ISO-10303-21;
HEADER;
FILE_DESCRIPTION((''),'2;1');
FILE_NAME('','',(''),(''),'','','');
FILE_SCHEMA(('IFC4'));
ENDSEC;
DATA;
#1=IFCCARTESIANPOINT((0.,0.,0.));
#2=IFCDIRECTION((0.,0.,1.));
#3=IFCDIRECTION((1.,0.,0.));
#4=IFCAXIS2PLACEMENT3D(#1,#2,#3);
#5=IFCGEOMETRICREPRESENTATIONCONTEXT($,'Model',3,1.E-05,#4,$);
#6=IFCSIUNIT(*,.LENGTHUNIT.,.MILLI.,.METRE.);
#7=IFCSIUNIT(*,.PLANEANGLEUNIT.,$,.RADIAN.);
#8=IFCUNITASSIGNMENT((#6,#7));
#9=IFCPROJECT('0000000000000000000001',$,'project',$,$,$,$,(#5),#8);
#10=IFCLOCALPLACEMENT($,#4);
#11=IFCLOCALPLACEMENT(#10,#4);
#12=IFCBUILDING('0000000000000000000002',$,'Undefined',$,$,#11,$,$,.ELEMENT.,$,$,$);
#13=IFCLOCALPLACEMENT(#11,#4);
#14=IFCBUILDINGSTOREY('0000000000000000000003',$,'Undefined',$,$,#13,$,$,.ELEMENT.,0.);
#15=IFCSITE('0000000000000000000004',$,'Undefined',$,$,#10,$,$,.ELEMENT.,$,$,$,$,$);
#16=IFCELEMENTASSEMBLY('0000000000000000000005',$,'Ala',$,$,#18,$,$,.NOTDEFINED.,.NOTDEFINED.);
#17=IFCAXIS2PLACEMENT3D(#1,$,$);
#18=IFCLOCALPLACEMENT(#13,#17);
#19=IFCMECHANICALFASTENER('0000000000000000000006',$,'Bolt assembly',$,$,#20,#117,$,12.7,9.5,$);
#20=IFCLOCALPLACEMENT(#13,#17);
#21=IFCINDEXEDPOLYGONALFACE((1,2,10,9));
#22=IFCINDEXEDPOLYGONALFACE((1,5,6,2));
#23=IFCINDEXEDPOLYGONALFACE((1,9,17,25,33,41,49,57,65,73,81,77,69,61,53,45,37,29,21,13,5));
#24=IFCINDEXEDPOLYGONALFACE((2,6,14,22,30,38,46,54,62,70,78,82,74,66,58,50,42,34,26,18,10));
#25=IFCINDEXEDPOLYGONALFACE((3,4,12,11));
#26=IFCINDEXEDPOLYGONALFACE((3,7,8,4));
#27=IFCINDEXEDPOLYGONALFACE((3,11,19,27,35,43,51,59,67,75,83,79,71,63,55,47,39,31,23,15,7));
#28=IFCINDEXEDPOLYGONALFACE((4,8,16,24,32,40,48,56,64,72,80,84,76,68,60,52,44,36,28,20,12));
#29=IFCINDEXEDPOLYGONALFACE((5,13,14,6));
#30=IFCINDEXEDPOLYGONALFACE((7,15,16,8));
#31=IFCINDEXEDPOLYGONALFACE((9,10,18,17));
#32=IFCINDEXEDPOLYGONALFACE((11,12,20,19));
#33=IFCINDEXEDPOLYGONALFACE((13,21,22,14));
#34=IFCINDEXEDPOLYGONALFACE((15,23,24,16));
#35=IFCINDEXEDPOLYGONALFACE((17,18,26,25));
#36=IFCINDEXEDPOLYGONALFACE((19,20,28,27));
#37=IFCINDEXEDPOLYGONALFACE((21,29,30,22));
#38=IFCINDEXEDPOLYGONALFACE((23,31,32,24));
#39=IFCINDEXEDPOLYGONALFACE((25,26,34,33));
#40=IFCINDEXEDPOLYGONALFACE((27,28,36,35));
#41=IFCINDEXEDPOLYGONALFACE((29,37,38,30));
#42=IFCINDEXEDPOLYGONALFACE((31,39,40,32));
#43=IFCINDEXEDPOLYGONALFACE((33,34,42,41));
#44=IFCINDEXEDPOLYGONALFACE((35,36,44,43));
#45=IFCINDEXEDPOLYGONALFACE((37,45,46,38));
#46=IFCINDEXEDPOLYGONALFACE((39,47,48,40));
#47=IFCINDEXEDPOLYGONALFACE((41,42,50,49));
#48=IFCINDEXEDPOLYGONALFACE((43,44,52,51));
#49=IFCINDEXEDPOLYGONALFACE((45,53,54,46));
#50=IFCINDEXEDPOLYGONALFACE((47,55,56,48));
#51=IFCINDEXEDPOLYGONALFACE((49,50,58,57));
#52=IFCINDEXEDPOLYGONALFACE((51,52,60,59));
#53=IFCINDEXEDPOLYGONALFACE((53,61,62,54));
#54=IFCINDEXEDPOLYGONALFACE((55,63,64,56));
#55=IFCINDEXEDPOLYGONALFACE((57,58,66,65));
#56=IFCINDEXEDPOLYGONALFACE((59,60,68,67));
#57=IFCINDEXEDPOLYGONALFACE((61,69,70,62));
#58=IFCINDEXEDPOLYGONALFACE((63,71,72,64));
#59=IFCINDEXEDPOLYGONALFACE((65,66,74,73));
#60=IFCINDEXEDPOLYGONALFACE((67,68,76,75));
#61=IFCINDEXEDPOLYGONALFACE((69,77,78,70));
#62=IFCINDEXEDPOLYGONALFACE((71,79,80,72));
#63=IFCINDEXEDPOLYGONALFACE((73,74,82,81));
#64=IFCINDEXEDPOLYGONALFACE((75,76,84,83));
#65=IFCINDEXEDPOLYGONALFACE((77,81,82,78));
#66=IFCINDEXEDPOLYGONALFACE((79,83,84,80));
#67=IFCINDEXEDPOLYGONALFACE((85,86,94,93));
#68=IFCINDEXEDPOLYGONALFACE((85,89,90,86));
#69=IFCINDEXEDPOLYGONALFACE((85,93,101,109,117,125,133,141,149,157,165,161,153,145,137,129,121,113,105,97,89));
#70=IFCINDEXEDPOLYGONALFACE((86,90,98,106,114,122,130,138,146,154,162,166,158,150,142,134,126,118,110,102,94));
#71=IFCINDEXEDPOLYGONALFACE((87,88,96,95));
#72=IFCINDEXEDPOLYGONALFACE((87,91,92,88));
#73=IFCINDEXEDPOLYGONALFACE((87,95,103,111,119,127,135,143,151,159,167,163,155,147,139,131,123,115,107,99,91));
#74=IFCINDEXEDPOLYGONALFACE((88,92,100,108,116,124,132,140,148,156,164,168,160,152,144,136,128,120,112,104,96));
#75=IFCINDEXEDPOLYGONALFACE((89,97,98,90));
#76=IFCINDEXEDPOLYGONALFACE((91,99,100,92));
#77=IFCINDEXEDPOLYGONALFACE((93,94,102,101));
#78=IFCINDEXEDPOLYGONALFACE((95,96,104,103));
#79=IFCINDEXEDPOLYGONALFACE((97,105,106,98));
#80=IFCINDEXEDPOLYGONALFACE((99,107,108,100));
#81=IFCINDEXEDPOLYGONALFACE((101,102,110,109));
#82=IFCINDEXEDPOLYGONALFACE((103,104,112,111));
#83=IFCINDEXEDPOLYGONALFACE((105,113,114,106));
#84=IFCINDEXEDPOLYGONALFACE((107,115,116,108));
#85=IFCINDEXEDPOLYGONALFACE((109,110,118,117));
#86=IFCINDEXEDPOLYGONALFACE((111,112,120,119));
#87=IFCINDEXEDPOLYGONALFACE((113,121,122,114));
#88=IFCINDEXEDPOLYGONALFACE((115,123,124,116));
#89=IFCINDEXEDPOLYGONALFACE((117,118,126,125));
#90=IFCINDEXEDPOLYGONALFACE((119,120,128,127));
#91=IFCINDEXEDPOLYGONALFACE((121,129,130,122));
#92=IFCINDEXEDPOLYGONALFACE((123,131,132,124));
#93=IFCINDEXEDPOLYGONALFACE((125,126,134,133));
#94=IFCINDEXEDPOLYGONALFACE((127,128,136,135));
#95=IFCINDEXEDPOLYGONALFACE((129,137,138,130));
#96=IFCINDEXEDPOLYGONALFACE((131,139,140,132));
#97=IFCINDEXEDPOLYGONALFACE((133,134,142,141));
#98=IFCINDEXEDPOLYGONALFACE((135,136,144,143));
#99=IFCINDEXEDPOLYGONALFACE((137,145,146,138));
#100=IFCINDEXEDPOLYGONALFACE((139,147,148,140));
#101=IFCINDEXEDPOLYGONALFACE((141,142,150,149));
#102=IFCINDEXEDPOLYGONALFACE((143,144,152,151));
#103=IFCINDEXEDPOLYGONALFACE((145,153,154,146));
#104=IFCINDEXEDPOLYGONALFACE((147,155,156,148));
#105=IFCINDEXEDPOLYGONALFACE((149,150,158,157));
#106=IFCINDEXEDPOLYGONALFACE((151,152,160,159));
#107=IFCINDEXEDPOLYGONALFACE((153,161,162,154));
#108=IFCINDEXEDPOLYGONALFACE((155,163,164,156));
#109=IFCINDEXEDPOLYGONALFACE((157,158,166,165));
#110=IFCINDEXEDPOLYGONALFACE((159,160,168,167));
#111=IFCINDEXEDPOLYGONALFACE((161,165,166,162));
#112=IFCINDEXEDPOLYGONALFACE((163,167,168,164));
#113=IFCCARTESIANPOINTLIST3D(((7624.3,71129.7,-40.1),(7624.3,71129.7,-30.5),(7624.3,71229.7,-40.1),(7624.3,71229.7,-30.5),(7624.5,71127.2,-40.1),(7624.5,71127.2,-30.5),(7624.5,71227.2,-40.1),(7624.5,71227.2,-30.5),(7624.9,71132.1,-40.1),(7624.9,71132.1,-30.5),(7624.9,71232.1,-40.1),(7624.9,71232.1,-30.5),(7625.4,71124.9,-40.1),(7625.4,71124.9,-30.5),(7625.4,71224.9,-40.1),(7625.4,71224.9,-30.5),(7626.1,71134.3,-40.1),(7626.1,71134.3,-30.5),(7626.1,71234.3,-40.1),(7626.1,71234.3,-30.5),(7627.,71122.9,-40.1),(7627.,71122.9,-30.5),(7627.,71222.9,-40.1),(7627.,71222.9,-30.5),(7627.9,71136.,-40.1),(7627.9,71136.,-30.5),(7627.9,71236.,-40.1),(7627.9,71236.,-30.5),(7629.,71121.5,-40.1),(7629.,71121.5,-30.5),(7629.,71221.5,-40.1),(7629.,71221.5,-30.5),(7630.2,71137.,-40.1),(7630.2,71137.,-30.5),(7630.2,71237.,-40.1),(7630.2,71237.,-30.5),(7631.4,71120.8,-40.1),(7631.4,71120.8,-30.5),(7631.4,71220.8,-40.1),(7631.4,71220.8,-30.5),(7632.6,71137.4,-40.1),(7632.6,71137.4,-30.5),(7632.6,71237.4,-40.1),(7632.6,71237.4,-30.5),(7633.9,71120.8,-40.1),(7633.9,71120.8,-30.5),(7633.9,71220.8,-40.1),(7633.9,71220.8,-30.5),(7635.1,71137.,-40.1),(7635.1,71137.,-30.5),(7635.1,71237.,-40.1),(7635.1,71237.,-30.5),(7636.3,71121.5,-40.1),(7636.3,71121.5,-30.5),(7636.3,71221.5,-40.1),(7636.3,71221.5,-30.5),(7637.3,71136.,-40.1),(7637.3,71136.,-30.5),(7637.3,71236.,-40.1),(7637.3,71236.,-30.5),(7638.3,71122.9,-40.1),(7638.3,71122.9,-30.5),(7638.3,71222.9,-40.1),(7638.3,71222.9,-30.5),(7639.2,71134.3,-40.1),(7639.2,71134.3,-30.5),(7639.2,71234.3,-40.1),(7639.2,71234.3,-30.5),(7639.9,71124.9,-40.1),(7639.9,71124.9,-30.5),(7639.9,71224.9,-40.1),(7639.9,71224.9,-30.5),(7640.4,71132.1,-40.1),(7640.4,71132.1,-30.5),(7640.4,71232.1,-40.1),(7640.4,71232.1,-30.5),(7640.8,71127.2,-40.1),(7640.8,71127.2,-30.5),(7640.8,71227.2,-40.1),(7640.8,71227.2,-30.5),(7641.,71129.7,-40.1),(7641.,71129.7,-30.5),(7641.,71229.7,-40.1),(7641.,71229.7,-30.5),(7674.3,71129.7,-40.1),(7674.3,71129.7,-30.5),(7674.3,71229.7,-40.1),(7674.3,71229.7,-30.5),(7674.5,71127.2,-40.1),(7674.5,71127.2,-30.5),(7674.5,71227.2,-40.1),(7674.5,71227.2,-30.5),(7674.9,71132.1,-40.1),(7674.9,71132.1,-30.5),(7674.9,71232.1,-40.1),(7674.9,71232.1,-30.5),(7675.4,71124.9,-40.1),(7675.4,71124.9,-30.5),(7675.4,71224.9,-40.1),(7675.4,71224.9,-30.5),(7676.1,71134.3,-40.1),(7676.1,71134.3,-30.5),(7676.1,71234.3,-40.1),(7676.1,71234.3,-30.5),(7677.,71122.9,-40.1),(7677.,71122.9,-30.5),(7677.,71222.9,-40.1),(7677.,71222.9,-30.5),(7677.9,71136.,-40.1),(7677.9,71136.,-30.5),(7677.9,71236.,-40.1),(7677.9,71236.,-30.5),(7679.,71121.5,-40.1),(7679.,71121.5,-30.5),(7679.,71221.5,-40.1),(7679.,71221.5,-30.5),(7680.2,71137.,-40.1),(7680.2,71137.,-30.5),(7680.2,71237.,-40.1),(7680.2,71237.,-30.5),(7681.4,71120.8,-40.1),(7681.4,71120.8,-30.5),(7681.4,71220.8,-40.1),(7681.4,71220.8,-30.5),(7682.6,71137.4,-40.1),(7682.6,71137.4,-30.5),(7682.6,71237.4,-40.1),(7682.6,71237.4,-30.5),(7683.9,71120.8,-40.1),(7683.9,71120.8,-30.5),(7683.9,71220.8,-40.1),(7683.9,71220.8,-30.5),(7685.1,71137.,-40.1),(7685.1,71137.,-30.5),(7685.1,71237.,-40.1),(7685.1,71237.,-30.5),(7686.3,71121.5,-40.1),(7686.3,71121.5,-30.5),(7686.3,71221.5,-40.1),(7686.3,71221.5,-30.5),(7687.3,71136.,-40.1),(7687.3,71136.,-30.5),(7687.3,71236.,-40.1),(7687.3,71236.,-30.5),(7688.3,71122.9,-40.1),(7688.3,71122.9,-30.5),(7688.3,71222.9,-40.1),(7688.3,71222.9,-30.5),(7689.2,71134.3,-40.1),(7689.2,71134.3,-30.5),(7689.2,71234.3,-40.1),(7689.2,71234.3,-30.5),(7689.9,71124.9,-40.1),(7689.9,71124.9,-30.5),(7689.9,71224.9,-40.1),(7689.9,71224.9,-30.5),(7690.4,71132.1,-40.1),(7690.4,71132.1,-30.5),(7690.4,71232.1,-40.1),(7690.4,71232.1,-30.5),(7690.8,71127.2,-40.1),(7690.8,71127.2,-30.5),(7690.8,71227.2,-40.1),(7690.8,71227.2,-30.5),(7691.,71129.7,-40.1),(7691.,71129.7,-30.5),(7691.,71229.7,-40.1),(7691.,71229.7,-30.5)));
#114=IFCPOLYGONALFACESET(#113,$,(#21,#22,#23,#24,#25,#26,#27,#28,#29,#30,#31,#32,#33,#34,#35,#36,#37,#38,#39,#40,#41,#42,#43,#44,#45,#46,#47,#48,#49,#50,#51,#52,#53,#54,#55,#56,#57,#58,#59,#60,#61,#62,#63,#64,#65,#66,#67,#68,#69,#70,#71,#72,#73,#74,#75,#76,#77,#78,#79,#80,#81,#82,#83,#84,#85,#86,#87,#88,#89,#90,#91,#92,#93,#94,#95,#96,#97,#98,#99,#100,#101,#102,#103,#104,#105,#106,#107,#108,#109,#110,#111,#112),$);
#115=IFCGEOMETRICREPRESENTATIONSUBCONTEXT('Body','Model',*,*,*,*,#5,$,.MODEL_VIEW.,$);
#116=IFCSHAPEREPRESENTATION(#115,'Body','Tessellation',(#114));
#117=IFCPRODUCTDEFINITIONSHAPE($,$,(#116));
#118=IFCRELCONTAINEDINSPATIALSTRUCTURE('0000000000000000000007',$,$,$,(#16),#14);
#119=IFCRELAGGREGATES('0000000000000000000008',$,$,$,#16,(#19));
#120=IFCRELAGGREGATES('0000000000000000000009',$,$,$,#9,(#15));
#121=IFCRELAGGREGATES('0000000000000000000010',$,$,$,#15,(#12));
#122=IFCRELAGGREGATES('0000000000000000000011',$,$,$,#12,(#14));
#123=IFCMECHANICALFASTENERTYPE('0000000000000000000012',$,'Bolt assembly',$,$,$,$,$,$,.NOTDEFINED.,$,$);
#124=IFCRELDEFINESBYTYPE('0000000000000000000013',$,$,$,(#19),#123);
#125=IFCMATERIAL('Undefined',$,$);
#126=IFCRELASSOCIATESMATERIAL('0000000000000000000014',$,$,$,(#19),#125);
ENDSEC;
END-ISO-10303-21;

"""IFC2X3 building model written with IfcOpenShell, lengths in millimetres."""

from ifc_helpers import new_model, si_unit, frame, origin_with_axes, origin_2d_with_axis, place, context, subcontext, project, spatial, circle, extrude, source, transform, mapped, material, type_object, element, aggregate, save


model = new_model("IFC2X3")

# Units and contexts
model_context = context("Model", 3, precision=1e-05, world=origin_with_axes())
body_context = subcontext(model_context, "Body", "Model", "MODEL_VIEW")
ifc_project = project(units=[si_unit("LENGTHUNIT", "METRE", prefix="MILLI"), si_unit("PLANEANGLEUNIT", "RADIAN")], contexts=[model_context])

# Site, building, storey
site_placement = place(None, origin_with_axes())
site = spatial("IfcSite", under=ifc_project, at=site_placement, Name="Undefined", CompositionType="ELEMENT")
building_placement = place(site_placement, origin_with_axes())
building = spatial("IfcBuilding", under=site, at=building_placement, Name="Undefined", CompositionType="ELEMENT")
storey_placement = place(building_placement, origin_with_axes())
storey = spatial("IfcBuildingStorey", under=building, at=storey_placement, Name="Undefined", CompositionType="ELEMENT", Elevation=0.0)

# Element assembly
assembly_1_placement = place(storey_placement, origin_with_axes())
assembly_1 = element("IfcElementAssembly", 1, at=assembly_1_placement, inside=storey, Name="Ala", AssemblyPlace="NOTDEFINED", PredefinedType="NOTDEFINED")

# Shared definitions
ifc_material_1 = material(Name="Undefined")
mechanical_fastener_type = type_object("IfcMechanicalFastenerType", Name="Bolt assembly")

# Mechanical fastener
shared_shape_1 = source(origin_with_axes(), body_context, "Body", "SweptSolid", [
    extrude(circle(Radius=8.4, at=origin_2d_with_axis()), frame((0.0, 0.0, 0.0), z_axis=(0.0, 1.0, 0.0), x_axis=(1.0, 0.0, 0.0)), (0.0, 0.0, 1.0), 9.6),
])
mechanical_fastener_1_placement = place(assembly_1_placement, frame((7657.6, 71129.1, -30.5), z_axis=(-1.0, 0.0, 0.0), x_axis=(0.0, 1.0, 0.0)))
mechanical_fastener_1 = element("IfcMechanicalFastener", 2, at=mechanical_fastener_1_placement, type_object=mechanical_fastener_type, material=ifc_material_1, Name="Bolt assembly", NominalDiameter=12.7, NominalLength=9.5, context=body_context, shape_type="MappedRepresentation", body=[
    mapped(shared_shape_1, transform((0.0, 0.0, -25.0))),
    mapped(shared_shape_1, transform((100.0, 0.0, -25.0))),
    mapped(shared_shape_1, transform((0.0, 0.0, 25.0))),
    mapped(shared_shape_1, transform((100.0, 0.0, 25.0))),
])
aggregate(assembly_1, [mechanical_fastener_1])

save(model, "model.ifc")
